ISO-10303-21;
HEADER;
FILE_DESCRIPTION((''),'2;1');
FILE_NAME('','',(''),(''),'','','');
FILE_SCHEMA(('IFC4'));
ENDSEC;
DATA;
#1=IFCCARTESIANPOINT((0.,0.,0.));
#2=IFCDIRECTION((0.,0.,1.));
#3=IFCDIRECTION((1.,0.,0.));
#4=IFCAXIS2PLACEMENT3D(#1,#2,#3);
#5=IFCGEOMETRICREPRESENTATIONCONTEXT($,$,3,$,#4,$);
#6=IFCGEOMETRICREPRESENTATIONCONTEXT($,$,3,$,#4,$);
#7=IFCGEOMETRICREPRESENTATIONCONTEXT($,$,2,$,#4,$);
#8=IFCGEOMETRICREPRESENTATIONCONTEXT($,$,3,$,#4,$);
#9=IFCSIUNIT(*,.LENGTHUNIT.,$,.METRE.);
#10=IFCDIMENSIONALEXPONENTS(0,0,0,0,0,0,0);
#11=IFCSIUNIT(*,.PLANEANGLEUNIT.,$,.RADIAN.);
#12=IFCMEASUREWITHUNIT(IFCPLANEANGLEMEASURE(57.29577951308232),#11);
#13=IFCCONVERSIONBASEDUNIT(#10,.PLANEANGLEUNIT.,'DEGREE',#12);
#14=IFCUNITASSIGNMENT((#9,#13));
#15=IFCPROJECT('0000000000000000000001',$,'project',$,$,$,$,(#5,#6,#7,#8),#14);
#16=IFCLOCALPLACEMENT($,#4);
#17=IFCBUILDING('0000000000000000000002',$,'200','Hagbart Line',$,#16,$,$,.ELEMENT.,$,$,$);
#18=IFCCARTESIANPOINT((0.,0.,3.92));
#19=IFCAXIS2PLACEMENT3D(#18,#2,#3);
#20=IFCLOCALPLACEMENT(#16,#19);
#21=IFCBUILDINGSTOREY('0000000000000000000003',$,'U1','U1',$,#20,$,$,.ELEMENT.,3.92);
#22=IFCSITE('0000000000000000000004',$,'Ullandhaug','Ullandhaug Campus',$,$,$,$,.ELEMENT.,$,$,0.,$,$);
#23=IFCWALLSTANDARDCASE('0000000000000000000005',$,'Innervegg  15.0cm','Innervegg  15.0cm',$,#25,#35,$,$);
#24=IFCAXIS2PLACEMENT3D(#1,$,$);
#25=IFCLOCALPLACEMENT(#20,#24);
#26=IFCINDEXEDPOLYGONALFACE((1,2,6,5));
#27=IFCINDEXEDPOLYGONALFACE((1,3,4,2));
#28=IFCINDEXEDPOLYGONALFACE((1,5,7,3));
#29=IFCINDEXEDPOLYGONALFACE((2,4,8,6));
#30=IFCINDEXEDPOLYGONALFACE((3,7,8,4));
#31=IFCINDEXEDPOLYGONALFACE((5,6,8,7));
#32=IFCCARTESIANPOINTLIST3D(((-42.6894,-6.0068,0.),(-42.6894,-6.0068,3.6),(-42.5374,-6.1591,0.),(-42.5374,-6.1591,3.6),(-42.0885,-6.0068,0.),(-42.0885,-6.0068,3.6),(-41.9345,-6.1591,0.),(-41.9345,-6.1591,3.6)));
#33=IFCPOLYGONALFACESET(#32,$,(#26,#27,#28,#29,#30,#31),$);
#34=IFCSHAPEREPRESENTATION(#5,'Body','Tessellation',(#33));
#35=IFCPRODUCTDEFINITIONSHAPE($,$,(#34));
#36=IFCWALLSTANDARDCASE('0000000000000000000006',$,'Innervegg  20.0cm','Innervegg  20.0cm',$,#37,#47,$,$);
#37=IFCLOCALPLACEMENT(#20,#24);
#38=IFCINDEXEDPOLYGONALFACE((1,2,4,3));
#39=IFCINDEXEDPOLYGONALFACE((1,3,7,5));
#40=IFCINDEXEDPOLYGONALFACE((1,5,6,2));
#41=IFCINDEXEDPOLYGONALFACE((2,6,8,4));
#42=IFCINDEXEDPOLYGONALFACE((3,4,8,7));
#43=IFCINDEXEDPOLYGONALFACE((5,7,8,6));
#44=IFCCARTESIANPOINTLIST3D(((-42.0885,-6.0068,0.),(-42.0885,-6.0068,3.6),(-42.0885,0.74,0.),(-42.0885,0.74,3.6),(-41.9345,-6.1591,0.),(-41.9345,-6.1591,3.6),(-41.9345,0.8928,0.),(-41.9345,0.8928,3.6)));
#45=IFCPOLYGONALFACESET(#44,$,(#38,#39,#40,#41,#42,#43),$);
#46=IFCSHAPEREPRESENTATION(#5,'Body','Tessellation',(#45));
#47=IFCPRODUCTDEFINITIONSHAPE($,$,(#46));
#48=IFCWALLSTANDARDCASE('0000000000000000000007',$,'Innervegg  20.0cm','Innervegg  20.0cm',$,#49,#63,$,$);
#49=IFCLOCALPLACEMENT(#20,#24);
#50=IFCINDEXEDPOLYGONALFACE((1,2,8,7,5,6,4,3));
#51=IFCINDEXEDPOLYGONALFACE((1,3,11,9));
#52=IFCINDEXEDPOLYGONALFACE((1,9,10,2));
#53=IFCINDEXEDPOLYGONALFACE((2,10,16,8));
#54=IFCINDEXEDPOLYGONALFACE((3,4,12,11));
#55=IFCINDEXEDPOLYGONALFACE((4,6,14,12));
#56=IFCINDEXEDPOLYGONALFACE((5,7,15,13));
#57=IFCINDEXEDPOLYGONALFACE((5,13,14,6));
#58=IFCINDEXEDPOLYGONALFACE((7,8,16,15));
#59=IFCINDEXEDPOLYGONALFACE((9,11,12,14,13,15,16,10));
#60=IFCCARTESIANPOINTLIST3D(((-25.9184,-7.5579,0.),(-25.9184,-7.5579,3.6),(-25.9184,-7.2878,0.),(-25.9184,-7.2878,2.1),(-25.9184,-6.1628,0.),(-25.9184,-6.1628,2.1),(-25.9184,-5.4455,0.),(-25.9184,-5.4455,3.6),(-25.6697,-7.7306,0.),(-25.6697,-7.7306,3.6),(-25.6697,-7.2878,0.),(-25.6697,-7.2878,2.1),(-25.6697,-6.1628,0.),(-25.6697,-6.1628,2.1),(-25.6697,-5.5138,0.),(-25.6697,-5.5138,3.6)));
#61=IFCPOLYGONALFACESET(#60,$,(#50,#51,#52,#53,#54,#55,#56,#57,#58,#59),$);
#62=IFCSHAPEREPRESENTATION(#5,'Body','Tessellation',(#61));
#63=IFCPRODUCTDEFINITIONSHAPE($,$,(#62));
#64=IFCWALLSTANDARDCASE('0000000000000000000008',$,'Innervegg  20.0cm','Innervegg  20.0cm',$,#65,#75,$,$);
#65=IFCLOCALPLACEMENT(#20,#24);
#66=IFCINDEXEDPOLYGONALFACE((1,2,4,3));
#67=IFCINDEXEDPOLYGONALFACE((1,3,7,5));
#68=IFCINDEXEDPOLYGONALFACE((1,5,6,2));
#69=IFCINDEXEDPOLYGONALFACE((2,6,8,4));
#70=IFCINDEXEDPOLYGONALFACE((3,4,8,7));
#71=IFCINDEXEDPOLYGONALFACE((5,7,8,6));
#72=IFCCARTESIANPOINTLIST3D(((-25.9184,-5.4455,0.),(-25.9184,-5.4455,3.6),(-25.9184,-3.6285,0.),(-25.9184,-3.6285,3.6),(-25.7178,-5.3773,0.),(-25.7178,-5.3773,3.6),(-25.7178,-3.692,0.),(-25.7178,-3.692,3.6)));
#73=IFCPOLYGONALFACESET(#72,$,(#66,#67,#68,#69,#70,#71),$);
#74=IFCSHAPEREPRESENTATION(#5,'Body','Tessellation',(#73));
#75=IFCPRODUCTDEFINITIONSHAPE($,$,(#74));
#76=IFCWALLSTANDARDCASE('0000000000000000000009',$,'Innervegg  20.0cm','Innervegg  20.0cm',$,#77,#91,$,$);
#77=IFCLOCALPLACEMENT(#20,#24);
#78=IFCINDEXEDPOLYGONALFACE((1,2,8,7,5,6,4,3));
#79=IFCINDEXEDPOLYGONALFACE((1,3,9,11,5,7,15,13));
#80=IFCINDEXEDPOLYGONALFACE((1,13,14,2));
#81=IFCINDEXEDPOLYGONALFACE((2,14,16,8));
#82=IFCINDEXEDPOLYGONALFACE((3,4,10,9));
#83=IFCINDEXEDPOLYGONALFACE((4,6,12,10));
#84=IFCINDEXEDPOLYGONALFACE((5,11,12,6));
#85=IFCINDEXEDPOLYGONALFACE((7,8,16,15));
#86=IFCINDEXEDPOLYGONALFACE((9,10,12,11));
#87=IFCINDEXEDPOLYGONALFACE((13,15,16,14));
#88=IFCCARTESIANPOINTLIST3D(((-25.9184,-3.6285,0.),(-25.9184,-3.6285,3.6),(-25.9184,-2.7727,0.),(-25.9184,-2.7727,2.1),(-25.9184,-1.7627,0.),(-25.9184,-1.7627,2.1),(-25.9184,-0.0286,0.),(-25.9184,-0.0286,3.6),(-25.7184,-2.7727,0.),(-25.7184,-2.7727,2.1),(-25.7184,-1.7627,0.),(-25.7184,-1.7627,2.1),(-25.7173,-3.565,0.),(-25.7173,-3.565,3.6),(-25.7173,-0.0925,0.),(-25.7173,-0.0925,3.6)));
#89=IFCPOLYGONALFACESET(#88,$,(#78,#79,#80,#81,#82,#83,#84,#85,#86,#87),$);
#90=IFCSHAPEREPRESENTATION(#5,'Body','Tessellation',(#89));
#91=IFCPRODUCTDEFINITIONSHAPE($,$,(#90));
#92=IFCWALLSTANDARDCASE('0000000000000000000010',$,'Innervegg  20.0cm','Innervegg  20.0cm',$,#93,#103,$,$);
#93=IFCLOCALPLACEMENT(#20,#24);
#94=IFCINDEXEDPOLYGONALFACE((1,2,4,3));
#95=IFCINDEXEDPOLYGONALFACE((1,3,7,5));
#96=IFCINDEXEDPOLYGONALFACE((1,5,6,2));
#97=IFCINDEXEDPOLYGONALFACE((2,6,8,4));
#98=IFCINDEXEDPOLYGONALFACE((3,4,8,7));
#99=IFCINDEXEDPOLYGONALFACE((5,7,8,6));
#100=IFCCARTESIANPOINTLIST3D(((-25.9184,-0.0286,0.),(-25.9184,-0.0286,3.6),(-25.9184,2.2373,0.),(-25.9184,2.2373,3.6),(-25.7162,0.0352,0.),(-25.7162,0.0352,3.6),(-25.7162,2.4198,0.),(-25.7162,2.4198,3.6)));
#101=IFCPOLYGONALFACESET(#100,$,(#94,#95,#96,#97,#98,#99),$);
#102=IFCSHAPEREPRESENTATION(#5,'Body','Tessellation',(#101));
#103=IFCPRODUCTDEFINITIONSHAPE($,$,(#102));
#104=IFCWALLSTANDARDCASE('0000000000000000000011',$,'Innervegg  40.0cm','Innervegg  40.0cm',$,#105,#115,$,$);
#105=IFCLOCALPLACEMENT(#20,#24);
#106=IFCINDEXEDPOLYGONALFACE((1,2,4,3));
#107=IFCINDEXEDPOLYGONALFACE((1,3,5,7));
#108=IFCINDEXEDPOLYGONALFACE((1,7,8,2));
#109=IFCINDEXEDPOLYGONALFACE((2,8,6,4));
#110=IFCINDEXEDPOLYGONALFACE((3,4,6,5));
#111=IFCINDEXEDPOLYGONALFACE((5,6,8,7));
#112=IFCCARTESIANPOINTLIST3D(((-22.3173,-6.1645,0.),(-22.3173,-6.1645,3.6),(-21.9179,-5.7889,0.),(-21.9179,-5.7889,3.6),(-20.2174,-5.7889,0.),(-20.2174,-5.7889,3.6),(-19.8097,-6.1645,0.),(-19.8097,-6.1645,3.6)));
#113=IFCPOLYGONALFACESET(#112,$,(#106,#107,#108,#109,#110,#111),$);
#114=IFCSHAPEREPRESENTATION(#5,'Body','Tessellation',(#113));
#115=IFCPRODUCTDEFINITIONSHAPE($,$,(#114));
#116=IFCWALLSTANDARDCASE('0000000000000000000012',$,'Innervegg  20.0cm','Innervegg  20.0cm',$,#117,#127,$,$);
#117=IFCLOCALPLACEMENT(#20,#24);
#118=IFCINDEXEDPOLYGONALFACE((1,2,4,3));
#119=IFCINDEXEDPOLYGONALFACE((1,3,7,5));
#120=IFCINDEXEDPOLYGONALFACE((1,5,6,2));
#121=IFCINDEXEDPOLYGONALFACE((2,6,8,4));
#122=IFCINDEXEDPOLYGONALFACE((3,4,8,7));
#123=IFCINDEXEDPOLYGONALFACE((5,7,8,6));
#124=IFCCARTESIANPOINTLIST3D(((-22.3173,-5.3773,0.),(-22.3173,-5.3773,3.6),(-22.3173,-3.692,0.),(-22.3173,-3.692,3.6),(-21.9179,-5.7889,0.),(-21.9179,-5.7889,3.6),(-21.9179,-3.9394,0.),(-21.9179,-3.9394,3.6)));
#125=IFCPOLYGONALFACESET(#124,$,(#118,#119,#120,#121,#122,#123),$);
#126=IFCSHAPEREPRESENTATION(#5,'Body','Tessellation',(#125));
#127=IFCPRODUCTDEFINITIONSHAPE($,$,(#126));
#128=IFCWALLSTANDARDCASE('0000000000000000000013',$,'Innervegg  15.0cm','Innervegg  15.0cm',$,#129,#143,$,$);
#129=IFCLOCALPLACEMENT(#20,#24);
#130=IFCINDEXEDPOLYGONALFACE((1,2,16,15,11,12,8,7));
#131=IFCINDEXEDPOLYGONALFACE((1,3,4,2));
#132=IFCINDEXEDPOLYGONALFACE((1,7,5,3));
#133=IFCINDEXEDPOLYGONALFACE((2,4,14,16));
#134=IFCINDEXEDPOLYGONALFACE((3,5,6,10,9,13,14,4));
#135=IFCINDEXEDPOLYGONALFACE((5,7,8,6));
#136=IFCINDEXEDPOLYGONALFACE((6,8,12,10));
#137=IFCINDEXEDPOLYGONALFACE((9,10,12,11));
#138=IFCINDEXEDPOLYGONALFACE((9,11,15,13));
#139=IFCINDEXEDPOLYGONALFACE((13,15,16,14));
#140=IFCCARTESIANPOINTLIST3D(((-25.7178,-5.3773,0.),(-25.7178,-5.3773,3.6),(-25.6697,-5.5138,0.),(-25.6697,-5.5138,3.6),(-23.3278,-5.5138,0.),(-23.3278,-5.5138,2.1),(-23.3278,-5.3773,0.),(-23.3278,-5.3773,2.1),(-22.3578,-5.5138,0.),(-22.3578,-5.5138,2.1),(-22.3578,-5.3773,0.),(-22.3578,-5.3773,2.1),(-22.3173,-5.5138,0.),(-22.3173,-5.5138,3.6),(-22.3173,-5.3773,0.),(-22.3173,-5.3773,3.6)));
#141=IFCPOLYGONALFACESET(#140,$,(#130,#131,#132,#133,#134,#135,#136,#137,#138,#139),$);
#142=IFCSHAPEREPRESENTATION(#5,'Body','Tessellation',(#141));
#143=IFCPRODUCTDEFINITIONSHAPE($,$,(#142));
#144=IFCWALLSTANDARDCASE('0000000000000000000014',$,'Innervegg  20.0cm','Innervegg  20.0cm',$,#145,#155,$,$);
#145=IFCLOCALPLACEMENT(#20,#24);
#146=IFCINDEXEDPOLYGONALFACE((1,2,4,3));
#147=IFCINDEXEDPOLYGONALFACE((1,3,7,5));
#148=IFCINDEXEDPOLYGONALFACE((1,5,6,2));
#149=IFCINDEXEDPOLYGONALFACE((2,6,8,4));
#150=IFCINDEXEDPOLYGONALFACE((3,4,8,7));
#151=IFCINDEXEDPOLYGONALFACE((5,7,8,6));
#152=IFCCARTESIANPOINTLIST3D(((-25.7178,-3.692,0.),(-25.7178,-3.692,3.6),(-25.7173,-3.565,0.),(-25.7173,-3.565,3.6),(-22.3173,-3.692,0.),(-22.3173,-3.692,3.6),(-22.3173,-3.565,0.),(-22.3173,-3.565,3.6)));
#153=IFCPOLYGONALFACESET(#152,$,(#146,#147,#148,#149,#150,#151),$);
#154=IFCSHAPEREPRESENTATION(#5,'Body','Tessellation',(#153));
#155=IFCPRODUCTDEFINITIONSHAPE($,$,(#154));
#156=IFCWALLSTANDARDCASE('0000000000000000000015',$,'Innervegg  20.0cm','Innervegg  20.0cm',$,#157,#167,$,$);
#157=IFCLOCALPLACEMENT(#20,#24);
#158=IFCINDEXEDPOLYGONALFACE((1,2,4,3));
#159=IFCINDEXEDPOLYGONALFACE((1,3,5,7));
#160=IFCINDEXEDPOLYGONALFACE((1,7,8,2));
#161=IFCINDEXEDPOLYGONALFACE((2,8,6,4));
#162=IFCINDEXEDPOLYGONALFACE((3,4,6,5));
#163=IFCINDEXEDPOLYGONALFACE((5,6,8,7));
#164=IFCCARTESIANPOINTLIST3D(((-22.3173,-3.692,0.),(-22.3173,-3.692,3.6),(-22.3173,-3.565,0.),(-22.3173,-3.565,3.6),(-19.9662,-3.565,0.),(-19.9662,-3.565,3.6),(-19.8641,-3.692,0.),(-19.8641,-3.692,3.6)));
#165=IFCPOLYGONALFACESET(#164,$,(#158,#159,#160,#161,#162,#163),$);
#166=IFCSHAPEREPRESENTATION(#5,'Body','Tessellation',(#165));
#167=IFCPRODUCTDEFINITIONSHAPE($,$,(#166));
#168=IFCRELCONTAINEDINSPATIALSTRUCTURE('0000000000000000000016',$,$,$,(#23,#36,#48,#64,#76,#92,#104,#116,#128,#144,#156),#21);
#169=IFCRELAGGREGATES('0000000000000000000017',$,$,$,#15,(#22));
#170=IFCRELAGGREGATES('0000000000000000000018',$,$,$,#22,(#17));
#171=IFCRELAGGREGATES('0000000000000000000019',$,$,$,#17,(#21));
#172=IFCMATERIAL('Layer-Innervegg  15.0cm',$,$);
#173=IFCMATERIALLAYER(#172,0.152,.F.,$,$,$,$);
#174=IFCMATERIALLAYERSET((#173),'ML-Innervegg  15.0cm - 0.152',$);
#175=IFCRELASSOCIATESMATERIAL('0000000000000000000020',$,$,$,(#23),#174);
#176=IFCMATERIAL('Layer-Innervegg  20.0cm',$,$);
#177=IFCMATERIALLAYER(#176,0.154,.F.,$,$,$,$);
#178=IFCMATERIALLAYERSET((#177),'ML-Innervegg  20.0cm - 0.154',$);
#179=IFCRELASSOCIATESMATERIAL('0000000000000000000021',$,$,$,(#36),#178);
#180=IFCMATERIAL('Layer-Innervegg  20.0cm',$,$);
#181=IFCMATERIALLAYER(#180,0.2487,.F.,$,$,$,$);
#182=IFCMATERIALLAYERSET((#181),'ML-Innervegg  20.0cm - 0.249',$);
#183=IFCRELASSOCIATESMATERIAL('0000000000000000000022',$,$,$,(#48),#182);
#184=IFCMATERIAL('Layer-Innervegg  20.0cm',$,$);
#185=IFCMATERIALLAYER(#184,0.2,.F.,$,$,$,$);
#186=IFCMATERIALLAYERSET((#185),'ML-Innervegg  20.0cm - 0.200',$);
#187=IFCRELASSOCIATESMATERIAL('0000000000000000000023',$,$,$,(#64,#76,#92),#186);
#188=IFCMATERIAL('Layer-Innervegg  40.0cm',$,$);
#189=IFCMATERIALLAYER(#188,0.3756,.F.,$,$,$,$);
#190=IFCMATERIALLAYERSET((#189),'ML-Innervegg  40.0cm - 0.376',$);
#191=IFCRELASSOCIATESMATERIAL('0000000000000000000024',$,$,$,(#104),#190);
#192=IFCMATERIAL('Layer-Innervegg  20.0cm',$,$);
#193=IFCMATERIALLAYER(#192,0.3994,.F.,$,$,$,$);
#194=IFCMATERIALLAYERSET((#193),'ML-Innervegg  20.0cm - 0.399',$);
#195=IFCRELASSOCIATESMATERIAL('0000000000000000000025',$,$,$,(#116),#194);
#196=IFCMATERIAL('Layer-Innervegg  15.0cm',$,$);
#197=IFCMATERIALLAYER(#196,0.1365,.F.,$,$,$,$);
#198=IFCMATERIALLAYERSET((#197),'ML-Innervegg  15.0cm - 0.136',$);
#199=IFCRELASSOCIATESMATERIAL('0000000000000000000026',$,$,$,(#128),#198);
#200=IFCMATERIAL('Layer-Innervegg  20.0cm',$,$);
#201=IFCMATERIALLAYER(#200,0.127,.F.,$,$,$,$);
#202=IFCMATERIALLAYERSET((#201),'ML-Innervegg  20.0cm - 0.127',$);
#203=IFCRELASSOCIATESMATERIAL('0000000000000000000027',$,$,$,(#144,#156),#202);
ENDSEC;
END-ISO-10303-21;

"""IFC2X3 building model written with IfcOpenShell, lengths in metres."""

from ifc_helpers import new_model, entity, si_unit, converted_unit, frame, origin_with_axes, place, context, project, spatial, polyline, outline, extrude, material, layer, layer_set, layer_usage, element, save


model = new_model("IFC2X3")

# Units and contexts
context_of_model_1 = context(None, 3, world=origin_with_axes())
context_of_model_2 = context(None, 3, world=origin_with_axes())
context_of_model_3 = context(None, 2, world=origin_with_axes())
context_of_model_4 = context(None, 3, world=origin_with_axes())
ifc_project = project(units=[si_unit("LENGTHUNIT", "METRE"), converted_unit("PLANEANGLEUNIT", "DEGREE", entity("IfcPlaneAngleMeasure", 57.29577951308232), si_unit("PLANEANGLEUNIT", "RADIAN"), dimensions=[0, 0, 0, 0, 0, 0, 0])], contexts=[context_of_model_1, context_of_model_2, context_of_model_3, context_of_model_4])

# Site, building, storey
site = spatial("IfcSite", under=ifc_project, Name="Ullandhaug", Description="Ullandhaug Campus", CompositionType="ELEMENT", RefElevation=0.0)
building_placement = place(None, origin_with_axes())
building = spatial("IfcBuilding", under=site, at=building_placement, Name="200", Description="Hagbart Line", CompositionType="ELEMENT")
storey_placement = place(building_placement, frame((0.0, 0.0, 3.92), z_axis=(0.0, 0.0, 1.0), x_axis=(1.0, 0.0, 0.0)))
storey = spatial("IfcBuildingStorey", under=building, at=storey_placement, Name="U1", Description="U1", CompositionType="ELEMENT", Elevation=3.92)

# Walls
ifc_material_1 = material(Name="Layer-Innervegg  20.0cm")
ifc_layer_1 = layer(ifc_material_1, 0.2, ventilated=False)
ifc_layer_set_1 = layer_set([ifc_layer_1], Name="ML-Innervegg  20.0cm - 0.200")
ifc_layer_usage_1 = layer_usage(ifc_layer_set_1, "AXIS2", "POSITIVE", 0.0)
ifc_material_2 = material(Name="Layer-Innervegg  15.0cm")
ifc_layer_2 = layer(ifc_material_2, 0.152, ventilated=False)
ifc_layer_set_2 = layer_set([ifc_layer_2], Name="ML-Innervegg  15.0cm - 0.152")
ifc_layer_usage_2 = layer_usage(ifc_layer_set_2, "AXIS2", "POSITIVE", 0.0)
wall_1_placement = place(storey_placement, frame((-42.5374, -6.1591, 0.0), z_axis=(0.0, 0.0, 1.0), x_axis=(1.0, 0.0, 0.0)))
element("IfcWallStandardCase", 1, at=wall_1_placement, inside=storey, material=ifc_layer_usage_2, Name="Innervegg  15.0cm", Description="Innervegg  15.0cm", context=context_of_model_1, shape_type="SweptSolid", body=[
    extrude(outline(polyline([(0.0, 0.0), (0.603, 0.0), (0.4489, 0.1522), (-0.152, 0.1522), (0.0, 0.0)])), origin_with_axes(), (0.0, 0.0, 1.0), 3.6),
])
ifc_material_3 = material(Name="Layer-Innervegg  20.0cm")
ifc_layer_3 = layer(ifc_material_3, 0.154, ventilated=False)
ifc_layer_set_3 = layer_set([ifc_layer_3], Name="ML-Innervegg  20.0cm - 0.154")
ifc_layer_usage_3 = layer_usage(ifc_layer_set_3, "AXIS2", "POSITIVE", 0.0)
wall_2_placement = place(storey_placement, frame((-41.9345, -6.1591, 0.0), z_axis=(0.0, 0.0, 1.0), x_axis=(0.0, 1.0, 0.0)))
element("IfcWallStandardCase", 2, at=wall_2_placement, inside=storey, material=ifc_layer_usage_3, Name="Innervegg  20.0cm", Description="Innervegg  20.0cm", context=context_of_model_1, shape_type="SweptSolid", body=[
    extrude(outline(polyline([(0.0, 0.0), (7.0519, 0.0), (6.899, 0.154), (0.1522, 0.154), (0.0, 0.0)])), frame((0.0, 0.0, 0.0), z_axis=(0.0, 0.0, 1.0), x_axis=(1.0, 0.0, 0.0)), (0.0, 0.0, 1.0), 3.6),
])

# Wall, opening
ifc_material_4 = material(Name="Layer-Innervegg  20.0cm")
ifc_layer_4 = layer(ifc_material_4, 0.2487, ventilated=False)
ifc_layer_set_4 = layer_set([ifc_layer_4], Name="ML-Innervegg  20.0cm - 0.249")
ifc_layer_usage_4 = layer_usage(ifc_layer_set_4, "AXIS2", "POSITIVE", 0.0)
wall_3_placement = place(storey_placement, frame((-25.6697, -7.7306, 0.0), z_axis=(0.0, 0.0, 1.0), x_axis=(0.0, 1.0, 0.0)))
wall_3 = element("IfcWallStandardCase", 3, at=wall_3_placement, inside=storey, material=ifc_layer_usage_4, Name="Innervegg  20.0cm", Description="Innervegg  20.0cm", context=context_of_model_1, shape_type="SweptSolid", body=[
    extrude(outline(polyline([(0.0, 0.0), (2.2168, 0.0), (2.285, 0.2487), (0.1727, 0.2487), (0.0, 0.0)])), frame((0.0, 0.0, 0.0), z_axis=(0.0, 0.0, 1.0), x_axis=(1.0, 0.0, 0.0)), (0.0, 0.0, 1.0), 3.6),
])
opening_1_placement = place(wall_3_placement, frame((0.4428, 0.2487, 0.0), z_axis=(0.0, 0.0, 1.0), x_axis=(1.0, 0.0, 0.0)))
element("IfcOpeningElement", 4, at=opening_1_placement, cuts=wall_3, context=context_of_model_1, shape_type="SweptSolid", body=[
    extrude(outline(polyline([(0.0, 0.0), (2.1, 0.0), (2.1, 1.125), (0.0, 1.125), (0.0, 0.0)])), frame((0.0, 0.0, 0.0), z_axis=(0.0, 1.0, 0.0), x_axis=(0.0, 0.0, 1.0)), (0.0, 0.0, -1.0), 0.2487),
])

# Wall
wall_4_placement = place(storey_placement, frame((-25.7178, -5.3773, 0.0), z_axis=(0.0, 0.0, 1.0), x_axis=(0.0, 1.0, 0.0)))
element("IfcWallStandardCase", 5, at=wall_4_placement, inside=storey, material=ifc_layer_usage_1, Name="Innervegg  20.0cm", Description="Innervegg  20.0cm", context=context_of_model_1, shape_type="SweptSolid", body=[
    extrude(outline(polyline([(0.0, 0.0), (1.6853, 0.0), (1.7488, 0.2006), (-0.0682, 0.2006), (0.0, 0.0)])), frame((0.0, 0.0, 0.0), z_axis=(0.0, 0.0, 1.0), x_axis=(1.0, 0.0, 0.0)), (0.0, 0.0, 1.0), 3.6),
])

# Wall, opening
wall_5_placement = place(storey_placement, frame((-25.7173, -3.565, 0.0), z_axis=(0.0, 0.0, 1.0), x_axis=(0.0, 1.0, 0.0)))
wall_5 = element("IfcWallStandardCase", 6, at=wall_5_placement, inside=storey, material=ifc_layer_usage_1, Name="Innervegg  20.0cm", Description="Innervegg  20.0cm", context=context_of_model_1, shape_type="SweptSolid", body=[
    extrude(outline(polyline([(0.0, 0.0), (3.4726, 0.0), (3.5364, 0.2012), (-0.0635, 0.2012), (0.0, 0.0)])), frame((0.0, 0.0, 0.0), z_axis=(0.0, 0.0, 1.0), x_axis=(1.0, 0.0, 0.0)), (0.0, 0.0, 1.0), 3.6),
])
opening_2_placement = place(wall_5_placement, frame((0.7923, 0.2012, 0.0), z_axis=(0.0, 0.0, 1.0), x_axis=(1.0, 0.0, 0.0)))
element("IfcOpeningElement", 7, at=opening_2_placement, cuts=wall_5, context=context_of_model_1, shape_type="SweptSolid", body=[
    extrude(outline(polyline([(0.0, 0.0), (2.1, 0.0), (2.1, 1.01), (0.0, 1.01), (0.0, 0.0)])), frame((0.0, 0.0, 0.0), z_axis=(0.0, 1.0, 0.0), x_axis=(0.0, 0.0, 1.0)), (0.0, 0.0, -1.0), 0.2),
])

# Walls
wall_6_placement = place(storey_placement, frame((-25.7162, 0.0352, 0.0), z_axis=(0.0, 0.0, 1.0), x_axis=(0.0, 1.0, 0.0)))
element("IfcWallStandardCase", 8, at=wall_6_placement, inside=storey, material=ifc_layer_usage_1, Name="Innervegg  20.0cm", Description="Innervegg  20.0cm", context=context_of_model_1, shape_type="SweptSolid", body=[
    extrude(outline(polyline([(0.0, 0.0), (2.3846, 0.0), (2.2021, 0.2022), (-0.0638, 0.2022), (0.0, 0.0)])), frame((0.0, 0.0, 0.0), z_axis=(0.0, 0.0, 1.0), x_axis=(1.0, 0.0, 0.0)), (0.0, 0.0, 1.0), 3.6),
])
ifc_material_5 = material(Name="Layer-Innervegg  40.0cm")
ifc_layer_5 = layer(ifc_material_5, 0.3756, ventilated=False)
ifc_layer_set_5 = layer_set([ifc_layer_5], Name="ML-Innervegg  40.0cm - 0.376")
ifc_layer_usage_5 = layer_usage(ifc_layer_set_5, "AXIS2", "POSITIVE", 0.0)
wall_7_placement = place(storey_placement, frame((-22.3173, -6.1645, 0.0), z_axis=(0.0, 0.0, 1.0), x_axis=(1.0, 0.0, 0.0)))
element("IfcWallStandardCase", 9, at=wall_7_placement, inside=storey, material=ifc_layer_usage_5, Name="Innervegg  40.0cm", Description="Innervegg  40.0cm", context=context_of_model_1, shape_type="SweptSolid", body=[
    extrude(outline(polyline([(0.0, 0.0), (2.5076, 0.0), (2.0999, 0.3756), (0.3994, 0.3756), (0.0, 0.0)])), frame((0.0, 0.0, 0.0), z_axis=(0.0, 0.0, 1.0), x_axis=(1.0, 0.0, 0.0)), (0.0, 0.0, 1.0), 3.6),
])
ifc_material_6 = material(Name="Layer-Innervegg  20.0cm")
ifc_layer_6 = layer(ifc_material_6, 0.3994, ventilated=False)
ifc_layer_set_6 = layer_set([ifc_layer_6], Name="ML-Innervegg  20.0cm - 0.399")
ifc_layer_usage_6 = layer_usage(ifc_layer_set_6, "AXIS2", "POSITIVE", 0.0)
wall_8_placement = place(storey_placement, frame((-22.3173, -3.692, 0.0), z_axis=(0.0, 0.0, 1.0), x_axis=(0.0, -1.0, 0.0)))
element("IfcWallStandardCase", 10, at=wall_8_placement, inside=storey, material=ifc_layer_usage_6, Name="Innervegg  20.0cm", Description="Innervegg  20.0cm", context=context_of_model_1, shape_type="SweptSolid", body=[
    extrude(outline(polyline([(0.0, 0.0), (1.6853, 0.0), (2.0969, 0.3994), (0.2474, 0.3994), (0.0, 0.0)])), frame((0.0, 0.0, 0.0), z_axis=(0.0, 0.0, 1.0), x_axis=(1.0, 0.0, 0.0)), (0.0, 0.0, 1.0), 3.6),
])

# Wall, opening
ifc_material_7 = material(Name="Layer-Innervegg  15.0cm")
ifc_layer_7 = layer(ifc_material_7, 0.1365, ventilated=False)
ifc_layer_set_7 = layer_set([ifc_layer_7], Name="ML-Innervegg  15.0cm - 0.136")
ifc_layer_usage_7 = layer_usage(ifc_layer_set_7, "AXIS2", "POSITIVE", 0.0)
wall_9_placement = place(storey_placement, frame((-25.6697, -5.5138, 0.0), z_axis=(0.0, 0.0, 1.0), x_axis=(1.0, 0.0, 0.0)))
wall_9 = element("IfcWallStandardCase", 11, at=wall_9_placement, inside=storey, material=ifc_layer_usage_7, Name="Innervegg  15.0cm", Description="Innervegg  15.0cm", context=context_of_model_1, shape_type="SweptSolid", body=[
    extrude(outline(polyline([(0.0, 0.0), (3.3524, 0.0), (3.3524, 0.1365), (-0.0481, 0.1365), (0.0, 0.0)])), origin_with_axes(), (0.0, 0.0, 1.0), 3.6),
])
opening_3_placement = place(wall_9_placement, frame((2.3419, 0.1365, 0.0), z_axis=(0.0, 0.0, 1.0), x_axis=(1.0, 0.0, 0.0)))
element("IfcOpeningElement", 12, at=opening_3_placement, cuts=wall_9, context=context_of_model_1, shape_type="SweptSolid", body=[
    extrude(outline(polyline([(0.0, 0.0), (2.1, 0.0), (2.1, 0.97), (0.0, 0.97), (0.0, 0.0)])), frame((0.0, 0.0, 0.0), z_axis=(0.0, 1.0, 0.0), x_axis=(0.0, 0.0, 1.0)), (0.0, 0.0, -1.0), 0.1365),
])

# Walls
ifc_material_8 = material(Name="Layer-Innervegg  20.0cm")
ifc_layer_8 = layer(ifc_material_8, 0.127, ventilated=False)
ifc_layer_set_8 = layer_set([ifc_layer_8], Name="ML-Innervegg  20.0cm - 0.127")
ifc_layer_usage_8 = layer_usage(ifc_layer_set_8, "AXIS2", "POSITIVE", 0.0)
wall_10_placement = place(storey_placement, frame((-22.3173, -3.565, 0.0), z_axis=(0.0, 0.0, 1.0), x_axis=(-1.0, 0.0, 0.0)))
element("IfcWallStandardCase", 13, at=wall_10_placement, inside=storey, material=ifc_layer_usage_8, Name="Innervegg  20.0cm", Description="Innervegg  20.0cm", context=context_of_model_1, shape_type="SweptSolid", body=[
    extrude(outline(polyline([(0.0, 0.0), (3.4, 0.0), (3.4005, 0.127), (0.0, 0.127), (0.0, 0.0)])), frame((0.0, 0.0, 0.0), z_axis=(0.0, 0.0, 1.0), x_axis=(1.0, 0.0, 0.0)), (0.0, 0.0, 1.0), 3.6),
])
wall_11_placement = place(storey_placement, frame((-22.3173, -3.692, 0.0), z_axis=(0.0, 0.0, 1.0), x_axis=(1.0, 0.0, 0.0)))
element("IfcWallStandardCase", 14, at=wall_11_placement, inside=storey, material=ifc_layer_usage_8, Name="Innervegg  20.0cm", Description="Innervegg  20.0cm", context=context_of_model_1, shape_type="SweptSolid", body=[
    extrude(outline(polyline([(0.0, 0.0), (2.4532, 0.0), (2.3511, 0.127), (0.0, 0.127), (0.0, 0.0)])), origin_with_axes(), (0.0, 0.0, 1.0), 3.6),
])

save(model, "model.ifc")
